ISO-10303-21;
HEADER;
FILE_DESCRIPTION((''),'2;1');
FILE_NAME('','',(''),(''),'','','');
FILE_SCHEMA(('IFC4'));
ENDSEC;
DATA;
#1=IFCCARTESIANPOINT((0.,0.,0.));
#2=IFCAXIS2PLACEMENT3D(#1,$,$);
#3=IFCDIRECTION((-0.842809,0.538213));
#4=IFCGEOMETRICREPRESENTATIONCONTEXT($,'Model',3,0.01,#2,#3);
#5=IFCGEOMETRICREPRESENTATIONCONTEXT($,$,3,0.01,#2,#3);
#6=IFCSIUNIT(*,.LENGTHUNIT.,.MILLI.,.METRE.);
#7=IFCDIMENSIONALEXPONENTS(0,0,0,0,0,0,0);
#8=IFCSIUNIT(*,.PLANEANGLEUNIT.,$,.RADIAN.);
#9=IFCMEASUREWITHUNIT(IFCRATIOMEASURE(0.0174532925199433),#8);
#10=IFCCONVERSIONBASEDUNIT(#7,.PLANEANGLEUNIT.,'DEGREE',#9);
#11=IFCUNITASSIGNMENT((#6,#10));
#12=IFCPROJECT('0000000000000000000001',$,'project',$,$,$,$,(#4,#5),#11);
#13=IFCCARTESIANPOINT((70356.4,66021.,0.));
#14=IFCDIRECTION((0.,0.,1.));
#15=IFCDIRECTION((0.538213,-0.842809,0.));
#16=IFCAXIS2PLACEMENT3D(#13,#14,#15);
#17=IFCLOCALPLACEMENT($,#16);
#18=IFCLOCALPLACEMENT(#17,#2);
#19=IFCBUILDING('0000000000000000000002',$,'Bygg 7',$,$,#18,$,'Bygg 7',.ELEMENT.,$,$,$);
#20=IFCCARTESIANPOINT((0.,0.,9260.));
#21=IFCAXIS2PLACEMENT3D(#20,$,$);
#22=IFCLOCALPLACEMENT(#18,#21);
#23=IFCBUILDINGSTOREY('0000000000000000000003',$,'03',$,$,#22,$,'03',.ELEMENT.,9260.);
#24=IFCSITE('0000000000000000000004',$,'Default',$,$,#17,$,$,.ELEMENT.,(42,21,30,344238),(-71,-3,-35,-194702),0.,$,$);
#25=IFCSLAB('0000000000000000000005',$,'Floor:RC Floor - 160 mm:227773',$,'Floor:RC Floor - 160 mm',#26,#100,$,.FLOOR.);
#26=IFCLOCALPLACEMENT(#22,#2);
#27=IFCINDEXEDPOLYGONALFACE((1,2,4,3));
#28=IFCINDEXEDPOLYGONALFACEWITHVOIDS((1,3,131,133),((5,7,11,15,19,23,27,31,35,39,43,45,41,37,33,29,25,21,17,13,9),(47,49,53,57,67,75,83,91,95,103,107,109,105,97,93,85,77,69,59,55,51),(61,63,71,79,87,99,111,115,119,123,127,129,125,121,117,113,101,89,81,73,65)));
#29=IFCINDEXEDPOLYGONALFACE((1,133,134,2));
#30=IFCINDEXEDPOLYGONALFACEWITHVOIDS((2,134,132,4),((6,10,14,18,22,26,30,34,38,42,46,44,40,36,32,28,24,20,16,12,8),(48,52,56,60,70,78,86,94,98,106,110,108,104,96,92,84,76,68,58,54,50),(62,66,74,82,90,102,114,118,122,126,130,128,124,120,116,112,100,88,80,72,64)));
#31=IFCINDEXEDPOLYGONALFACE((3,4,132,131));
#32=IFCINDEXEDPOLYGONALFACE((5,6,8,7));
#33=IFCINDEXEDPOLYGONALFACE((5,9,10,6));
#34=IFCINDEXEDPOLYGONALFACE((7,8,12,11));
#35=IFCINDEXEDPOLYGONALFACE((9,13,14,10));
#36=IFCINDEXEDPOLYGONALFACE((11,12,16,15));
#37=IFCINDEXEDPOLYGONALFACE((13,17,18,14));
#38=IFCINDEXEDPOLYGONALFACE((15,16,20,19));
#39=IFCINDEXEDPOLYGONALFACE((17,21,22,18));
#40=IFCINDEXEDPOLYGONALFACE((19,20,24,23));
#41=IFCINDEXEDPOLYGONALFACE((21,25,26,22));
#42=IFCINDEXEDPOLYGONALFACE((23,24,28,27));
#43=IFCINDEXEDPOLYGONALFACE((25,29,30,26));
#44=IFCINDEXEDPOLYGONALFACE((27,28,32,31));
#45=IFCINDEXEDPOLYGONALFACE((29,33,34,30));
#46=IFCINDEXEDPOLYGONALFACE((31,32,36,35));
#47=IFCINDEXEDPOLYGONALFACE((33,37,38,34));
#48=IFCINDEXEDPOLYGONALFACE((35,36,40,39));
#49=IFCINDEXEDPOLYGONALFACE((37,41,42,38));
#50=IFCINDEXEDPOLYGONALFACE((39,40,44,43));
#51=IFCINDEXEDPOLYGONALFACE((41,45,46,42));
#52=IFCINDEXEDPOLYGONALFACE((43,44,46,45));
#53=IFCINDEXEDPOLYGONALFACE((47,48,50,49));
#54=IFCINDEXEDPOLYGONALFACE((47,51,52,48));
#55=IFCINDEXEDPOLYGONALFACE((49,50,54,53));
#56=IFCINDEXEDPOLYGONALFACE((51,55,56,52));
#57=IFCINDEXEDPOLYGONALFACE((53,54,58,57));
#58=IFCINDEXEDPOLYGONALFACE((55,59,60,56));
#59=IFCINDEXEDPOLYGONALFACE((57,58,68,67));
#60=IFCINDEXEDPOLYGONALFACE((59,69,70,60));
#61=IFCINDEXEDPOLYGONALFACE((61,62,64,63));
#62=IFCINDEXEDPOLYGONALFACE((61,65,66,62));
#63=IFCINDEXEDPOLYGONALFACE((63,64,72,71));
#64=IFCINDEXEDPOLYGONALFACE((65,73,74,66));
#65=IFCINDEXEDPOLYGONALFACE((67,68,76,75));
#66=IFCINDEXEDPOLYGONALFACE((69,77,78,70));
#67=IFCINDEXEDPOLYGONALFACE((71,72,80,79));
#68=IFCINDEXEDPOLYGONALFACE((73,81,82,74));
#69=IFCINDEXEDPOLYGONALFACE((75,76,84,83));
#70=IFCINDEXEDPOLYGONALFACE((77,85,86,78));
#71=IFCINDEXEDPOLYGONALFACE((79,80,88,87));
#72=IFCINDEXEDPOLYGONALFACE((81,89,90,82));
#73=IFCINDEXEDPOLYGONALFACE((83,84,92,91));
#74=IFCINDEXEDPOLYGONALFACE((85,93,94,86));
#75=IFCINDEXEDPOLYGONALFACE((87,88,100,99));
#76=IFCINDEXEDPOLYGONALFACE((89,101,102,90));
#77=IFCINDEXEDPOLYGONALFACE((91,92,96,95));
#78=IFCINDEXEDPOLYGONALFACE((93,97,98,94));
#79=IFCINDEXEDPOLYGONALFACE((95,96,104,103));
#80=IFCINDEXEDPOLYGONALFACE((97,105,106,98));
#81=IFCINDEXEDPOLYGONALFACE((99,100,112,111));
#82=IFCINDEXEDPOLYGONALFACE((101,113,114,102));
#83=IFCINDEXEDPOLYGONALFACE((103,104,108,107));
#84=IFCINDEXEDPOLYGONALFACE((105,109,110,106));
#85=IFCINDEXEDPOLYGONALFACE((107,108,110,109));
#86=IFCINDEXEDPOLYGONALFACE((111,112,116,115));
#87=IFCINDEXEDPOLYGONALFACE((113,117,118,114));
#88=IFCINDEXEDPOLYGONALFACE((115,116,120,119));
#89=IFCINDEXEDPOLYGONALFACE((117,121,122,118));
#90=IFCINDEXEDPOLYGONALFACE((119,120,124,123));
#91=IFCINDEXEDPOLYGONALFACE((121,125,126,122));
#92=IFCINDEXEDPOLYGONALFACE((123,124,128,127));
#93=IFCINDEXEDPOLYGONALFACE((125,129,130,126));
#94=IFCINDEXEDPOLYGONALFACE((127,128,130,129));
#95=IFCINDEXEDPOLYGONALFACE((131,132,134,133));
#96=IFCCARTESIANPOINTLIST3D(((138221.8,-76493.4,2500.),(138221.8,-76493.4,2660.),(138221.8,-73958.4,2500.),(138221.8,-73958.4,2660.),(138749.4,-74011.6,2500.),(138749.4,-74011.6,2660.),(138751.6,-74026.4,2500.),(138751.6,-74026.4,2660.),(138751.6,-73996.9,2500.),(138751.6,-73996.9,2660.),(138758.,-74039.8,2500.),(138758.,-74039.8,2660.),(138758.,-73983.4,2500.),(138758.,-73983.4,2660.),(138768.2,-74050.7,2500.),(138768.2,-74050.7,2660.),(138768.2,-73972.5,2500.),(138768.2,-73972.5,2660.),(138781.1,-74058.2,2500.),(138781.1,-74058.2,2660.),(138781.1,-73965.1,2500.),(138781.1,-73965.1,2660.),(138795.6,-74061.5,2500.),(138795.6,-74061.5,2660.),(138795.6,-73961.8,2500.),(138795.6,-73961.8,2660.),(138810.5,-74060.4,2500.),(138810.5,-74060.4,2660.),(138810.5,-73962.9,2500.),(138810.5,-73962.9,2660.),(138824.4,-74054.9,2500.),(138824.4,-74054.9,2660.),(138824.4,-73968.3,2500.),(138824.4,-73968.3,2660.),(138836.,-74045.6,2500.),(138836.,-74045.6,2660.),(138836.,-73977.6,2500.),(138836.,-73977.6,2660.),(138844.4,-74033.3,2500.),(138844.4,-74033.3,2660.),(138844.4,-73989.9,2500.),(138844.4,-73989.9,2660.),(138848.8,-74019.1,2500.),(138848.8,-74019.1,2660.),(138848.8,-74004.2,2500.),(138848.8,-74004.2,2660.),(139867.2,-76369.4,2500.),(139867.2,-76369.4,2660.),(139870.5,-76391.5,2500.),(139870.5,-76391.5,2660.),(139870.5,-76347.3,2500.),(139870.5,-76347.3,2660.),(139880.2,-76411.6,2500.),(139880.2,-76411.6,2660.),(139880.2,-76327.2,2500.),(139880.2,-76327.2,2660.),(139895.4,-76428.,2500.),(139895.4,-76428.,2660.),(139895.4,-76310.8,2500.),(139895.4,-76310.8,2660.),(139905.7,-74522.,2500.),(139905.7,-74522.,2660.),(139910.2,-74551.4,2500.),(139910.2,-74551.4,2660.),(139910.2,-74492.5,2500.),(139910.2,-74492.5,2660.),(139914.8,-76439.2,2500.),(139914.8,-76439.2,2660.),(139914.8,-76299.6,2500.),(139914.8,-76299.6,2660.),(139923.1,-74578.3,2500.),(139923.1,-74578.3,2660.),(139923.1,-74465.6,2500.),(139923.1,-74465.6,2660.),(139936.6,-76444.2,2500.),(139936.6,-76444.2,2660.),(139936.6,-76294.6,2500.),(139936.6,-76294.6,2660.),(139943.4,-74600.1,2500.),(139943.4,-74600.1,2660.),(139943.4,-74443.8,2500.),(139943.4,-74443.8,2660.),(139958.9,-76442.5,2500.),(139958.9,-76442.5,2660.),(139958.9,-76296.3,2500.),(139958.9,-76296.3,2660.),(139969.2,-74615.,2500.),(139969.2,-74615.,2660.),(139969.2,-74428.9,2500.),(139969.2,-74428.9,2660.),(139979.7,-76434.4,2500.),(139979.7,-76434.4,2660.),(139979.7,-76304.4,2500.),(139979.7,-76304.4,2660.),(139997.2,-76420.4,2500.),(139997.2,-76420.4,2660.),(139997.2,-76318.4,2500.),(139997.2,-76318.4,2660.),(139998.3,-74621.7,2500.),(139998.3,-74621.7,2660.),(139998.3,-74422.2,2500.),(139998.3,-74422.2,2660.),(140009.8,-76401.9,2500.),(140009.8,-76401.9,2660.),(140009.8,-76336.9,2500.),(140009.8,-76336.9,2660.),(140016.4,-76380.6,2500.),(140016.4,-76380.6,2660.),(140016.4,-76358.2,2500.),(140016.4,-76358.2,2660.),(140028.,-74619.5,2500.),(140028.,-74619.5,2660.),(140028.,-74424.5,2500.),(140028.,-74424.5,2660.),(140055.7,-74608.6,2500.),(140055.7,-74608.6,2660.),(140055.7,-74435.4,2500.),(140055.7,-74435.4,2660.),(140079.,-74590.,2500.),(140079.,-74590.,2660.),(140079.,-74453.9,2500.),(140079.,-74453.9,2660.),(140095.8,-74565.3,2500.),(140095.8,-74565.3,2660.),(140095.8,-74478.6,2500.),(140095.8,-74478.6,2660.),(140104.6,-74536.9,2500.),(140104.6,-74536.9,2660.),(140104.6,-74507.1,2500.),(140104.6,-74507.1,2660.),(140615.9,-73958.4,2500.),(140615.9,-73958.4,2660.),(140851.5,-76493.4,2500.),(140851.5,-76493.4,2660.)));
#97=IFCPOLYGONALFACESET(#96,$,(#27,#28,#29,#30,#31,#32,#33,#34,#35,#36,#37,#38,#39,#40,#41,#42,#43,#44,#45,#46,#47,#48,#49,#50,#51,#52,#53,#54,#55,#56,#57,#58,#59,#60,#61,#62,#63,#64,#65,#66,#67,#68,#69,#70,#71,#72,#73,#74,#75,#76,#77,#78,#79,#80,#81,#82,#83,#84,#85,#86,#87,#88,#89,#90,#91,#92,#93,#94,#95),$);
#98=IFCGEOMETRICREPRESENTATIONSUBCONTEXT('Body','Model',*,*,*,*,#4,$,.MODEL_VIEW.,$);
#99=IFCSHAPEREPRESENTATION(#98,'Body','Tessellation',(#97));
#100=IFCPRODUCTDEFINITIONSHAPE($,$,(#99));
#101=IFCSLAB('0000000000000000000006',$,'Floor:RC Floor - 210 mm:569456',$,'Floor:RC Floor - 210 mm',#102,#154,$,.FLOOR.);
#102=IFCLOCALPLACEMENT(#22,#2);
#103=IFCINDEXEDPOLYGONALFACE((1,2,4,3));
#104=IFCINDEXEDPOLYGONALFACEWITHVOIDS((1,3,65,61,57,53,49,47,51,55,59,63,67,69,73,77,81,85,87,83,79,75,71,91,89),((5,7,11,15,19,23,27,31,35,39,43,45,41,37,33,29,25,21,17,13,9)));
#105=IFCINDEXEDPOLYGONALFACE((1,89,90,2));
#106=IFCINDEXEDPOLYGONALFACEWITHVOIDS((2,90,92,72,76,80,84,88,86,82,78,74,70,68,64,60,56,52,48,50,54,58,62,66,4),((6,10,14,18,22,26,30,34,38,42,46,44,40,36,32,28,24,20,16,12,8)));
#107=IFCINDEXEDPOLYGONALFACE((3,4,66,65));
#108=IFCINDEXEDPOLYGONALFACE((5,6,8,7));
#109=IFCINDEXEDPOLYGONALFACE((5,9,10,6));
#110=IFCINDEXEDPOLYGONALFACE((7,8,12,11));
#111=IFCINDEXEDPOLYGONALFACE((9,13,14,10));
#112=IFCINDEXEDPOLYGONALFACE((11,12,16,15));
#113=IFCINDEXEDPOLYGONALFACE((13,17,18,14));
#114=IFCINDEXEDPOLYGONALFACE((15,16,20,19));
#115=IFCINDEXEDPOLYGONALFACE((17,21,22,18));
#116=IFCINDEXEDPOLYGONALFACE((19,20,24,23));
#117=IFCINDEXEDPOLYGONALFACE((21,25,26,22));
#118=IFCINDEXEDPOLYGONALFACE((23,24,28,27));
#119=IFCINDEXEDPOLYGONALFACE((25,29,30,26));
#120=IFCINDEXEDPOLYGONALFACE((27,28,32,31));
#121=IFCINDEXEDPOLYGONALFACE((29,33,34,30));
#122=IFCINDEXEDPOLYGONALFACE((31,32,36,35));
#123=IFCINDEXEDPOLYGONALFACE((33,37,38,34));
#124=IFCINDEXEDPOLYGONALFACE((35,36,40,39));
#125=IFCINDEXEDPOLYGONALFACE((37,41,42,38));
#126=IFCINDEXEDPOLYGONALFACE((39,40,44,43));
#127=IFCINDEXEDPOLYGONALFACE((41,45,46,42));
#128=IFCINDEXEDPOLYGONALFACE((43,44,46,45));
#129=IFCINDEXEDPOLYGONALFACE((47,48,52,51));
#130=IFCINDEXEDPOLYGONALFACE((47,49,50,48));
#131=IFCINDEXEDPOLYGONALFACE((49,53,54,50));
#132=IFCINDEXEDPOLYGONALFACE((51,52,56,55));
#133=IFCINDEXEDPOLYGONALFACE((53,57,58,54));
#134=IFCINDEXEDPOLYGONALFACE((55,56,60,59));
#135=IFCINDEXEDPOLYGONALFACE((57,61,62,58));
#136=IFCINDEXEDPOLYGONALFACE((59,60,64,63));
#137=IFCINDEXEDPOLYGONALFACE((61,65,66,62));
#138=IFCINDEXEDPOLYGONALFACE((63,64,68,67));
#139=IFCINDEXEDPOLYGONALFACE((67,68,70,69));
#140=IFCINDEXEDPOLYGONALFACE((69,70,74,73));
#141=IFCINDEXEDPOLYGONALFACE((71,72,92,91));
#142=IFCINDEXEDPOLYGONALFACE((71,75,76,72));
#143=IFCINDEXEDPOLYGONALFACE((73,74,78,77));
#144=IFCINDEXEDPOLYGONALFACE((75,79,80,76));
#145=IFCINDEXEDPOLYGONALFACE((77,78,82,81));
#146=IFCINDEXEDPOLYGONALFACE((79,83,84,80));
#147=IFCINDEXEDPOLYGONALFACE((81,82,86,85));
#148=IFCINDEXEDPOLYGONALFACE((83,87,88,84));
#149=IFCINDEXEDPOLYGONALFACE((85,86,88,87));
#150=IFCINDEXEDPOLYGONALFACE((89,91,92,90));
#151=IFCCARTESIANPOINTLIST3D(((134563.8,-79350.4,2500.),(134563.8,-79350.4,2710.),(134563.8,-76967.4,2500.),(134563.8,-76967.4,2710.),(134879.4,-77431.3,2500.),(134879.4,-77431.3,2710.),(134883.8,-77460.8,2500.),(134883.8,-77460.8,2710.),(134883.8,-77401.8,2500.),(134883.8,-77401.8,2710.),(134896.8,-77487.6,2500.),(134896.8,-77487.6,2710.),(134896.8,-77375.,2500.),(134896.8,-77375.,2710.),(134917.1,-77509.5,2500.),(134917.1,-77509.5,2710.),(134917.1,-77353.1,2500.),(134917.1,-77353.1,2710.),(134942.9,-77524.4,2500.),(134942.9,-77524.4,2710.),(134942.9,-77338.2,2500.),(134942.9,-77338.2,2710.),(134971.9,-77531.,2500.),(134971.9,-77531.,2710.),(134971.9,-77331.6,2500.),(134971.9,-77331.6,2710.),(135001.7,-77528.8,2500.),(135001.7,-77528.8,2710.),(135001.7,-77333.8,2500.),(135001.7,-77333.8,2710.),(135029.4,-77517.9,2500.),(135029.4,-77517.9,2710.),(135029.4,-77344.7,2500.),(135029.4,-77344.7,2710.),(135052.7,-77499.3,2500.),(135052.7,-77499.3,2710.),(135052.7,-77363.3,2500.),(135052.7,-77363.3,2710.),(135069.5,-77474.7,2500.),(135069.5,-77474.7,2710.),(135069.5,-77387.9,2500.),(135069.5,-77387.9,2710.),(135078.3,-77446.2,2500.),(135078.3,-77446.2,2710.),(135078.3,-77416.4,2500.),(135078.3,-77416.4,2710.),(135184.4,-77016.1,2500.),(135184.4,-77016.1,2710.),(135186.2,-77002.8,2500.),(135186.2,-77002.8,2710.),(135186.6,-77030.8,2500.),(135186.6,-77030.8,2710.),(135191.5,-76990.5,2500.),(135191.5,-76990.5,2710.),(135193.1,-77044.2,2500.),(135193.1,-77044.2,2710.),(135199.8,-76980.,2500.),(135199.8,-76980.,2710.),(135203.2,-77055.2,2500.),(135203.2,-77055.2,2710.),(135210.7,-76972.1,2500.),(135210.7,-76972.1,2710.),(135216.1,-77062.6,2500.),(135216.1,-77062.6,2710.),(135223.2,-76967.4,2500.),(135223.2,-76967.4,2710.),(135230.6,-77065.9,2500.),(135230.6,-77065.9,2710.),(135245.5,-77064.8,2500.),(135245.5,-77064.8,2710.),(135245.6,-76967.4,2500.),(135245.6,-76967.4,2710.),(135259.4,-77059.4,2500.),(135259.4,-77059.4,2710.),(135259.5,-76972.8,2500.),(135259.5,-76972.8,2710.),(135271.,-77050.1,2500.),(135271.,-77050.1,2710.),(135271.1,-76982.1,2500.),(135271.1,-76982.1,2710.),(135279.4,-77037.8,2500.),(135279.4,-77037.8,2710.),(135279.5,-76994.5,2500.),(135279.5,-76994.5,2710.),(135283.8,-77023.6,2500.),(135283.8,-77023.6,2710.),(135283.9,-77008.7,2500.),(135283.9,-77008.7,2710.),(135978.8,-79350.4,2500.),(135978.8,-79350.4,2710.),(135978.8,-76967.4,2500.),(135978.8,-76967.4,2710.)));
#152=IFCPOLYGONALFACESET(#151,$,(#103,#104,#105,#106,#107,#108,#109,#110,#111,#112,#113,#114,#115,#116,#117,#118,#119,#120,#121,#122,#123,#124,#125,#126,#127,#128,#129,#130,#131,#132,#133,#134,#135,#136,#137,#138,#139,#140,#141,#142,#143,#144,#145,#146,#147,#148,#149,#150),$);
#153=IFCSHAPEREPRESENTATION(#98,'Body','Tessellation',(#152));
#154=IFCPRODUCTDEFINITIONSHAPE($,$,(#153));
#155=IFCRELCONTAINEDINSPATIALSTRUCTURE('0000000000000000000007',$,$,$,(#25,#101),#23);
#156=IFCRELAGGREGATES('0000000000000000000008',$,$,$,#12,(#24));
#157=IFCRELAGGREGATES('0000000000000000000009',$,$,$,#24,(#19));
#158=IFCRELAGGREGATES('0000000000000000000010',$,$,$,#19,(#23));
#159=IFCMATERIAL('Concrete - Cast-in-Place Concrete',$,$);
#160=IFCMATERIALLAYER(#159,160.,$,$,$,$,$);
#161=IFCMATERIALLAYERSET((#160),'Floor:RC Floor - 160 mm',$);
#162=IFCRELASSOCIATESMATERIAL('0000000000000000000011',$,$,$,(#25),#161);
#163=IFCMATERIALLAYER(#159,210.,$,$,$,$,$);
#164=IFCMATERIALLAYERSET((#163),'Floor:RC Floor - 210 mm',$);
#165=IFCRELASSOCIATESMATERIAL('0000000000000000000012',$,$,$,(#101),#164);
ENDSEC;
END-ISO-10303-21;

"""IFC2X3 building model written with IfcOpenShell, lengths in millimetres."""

from ifc_helpers import new_model, entity, si_unit, converted_unit, direction, frame, frame_2d, origin, place, context, subcontext, project, spatial, polyline, rectangle, circle, outline, extrude, material, layer, layer_set, layer_usage, element, save


model = new_model("IFC2X3")

# Units and contexts
model_context = context("Model", 3, precision=0.01, world=origin(), true_north=direction((-0.842809, 0.538213)))
context_of_model = context(None, 3, precision=0.01, world=origin(), true_north=direction((-0.842809, 0.538213)))
body_context = subcontext(model_context, "Body", "Model", "MODEL_VIEW")
ifc_project = project(units=[si_unit("LENGTHUNIT", "METRE", prefix="MILLI"), converted_unit("PLANEANGLEUNIT", "DEGREE", entity("IfcRatioMeasure", 0.0174532925199433), si_unit("PLANEANGLEUNIT", "RADIAN"), dimensions=[0, 0, 0, 0, 0, 0, 0])], contexts=[model_context, context_of_model])

# Site, building, storey
site_placement = place(None, frame((70356.4, 66021.0, 0.0), z_axis=(0.0, 0.0, 1.0), x_axis=(0.538213, -0.842809, 0.0)))
site = spatial("IfcSite", under=ifc_project, at=site_placement, Name="Default", CompositionType="ELEMENT", RefLatitude=(42, 21, 30, 344238), RefLongitude=(-71, -3, -35, -194702), RefElevation=0.0)
building_placement = place(site_placement, origin())
building = spatial("IfcBuilding", under=site, at=building_placement, Name="Bygg 7", LongName="Bygg 7", CompositionType="ELEMENT")
storey_placement = place(building_placement, frame((0.0, 0.0, 9260.0)))
storey = spatial("IfcBuildingStorey", under=building, at=storey_placement, Name="03", LongName="03", CompositionType="ELEMENT", Elevation=9260.0)

# Slabs, openings
ifc_material_1 = material(Name="Concrete - Cast-in-Place Concrete")
ifc_layer_1 = layer(ifc_material_1, 160.0)
ifc_layer_set_1 = layer_set([ifc_layer_1], Name="Floor:RC Floor - 160 mm")
ifc_layer_usage_1 = layer_usage(ifc_layer_set_1, "AXIS3", "POSITIVE", 0.0)
slab_1_placement = place(storey_placement, frame((138221.8, -76493.4, 2500.0)))
slab_1 = element("IfcSlab", 1, at=slab_1_placement, inside=storey, material=ifc_layer_usage_1, Name="Floor:RC Floor - 160 mm:227773", ObjectType="Floor:RC Floor - 160 mm", PredefinedType="FLOOR", context=body_context, shape_type="SweptSolid", body=[
    extrude(outline(polyline([(1314.8, 1267.5), (-1079.2, 1267.5), (-1314.8, -1267.5), (1314.8, -1267.5), (1314.8, 1267.5)])), frame((1314.8, 1267.5, 160.0), z_axis=(0.0, 0.0, -1.0), x_axis=(-1.0, 0.0, 0.0)), (0.0, 0.0, 1.0), 160.0),
])
opening_1_placement = place(storey_placement, frame((138221.8, -76493.4, 2500.0)))
element("IfcOpeningElement", 2, at=opening_1_placement, cuts=slab_1, ObjectType="Opening", context=body_context, shape_type="SweptSolid", body=[
    extrude(circle(Radius=75.0, at=frame_2d((-405.6, -1143.5), x_axis=(1.0, 0.0))), frame((1314.8, 1267.5, 160.0), z_axis=(0.0, 0.0, -1.0), x_axis=(-1.0, 0.0, 0.0)), (0.0, 0.0, 1.0), 160.0),
])
opening_2_placement = place(storey_placement, frame((138221.8, -76493.4, 2500.0)))
element("IfcOpeningElement", 3, at=opening_2_placement, cuts=slab_1, ObjectType="Opening", context=body_context, shape_type="SweptSolid", body=[
    extrude(circle(Radius=50.0, at=frame_2d((737.3, 1214.2), x_axis=(1.0, 0.0))), frame((1314.8, 1267.5, 160.0), z_axis=(0.0, 0.0, -1.0), x_axis=(-1.0, 0.0, 0.0)), (0.0, 0.0, 1.0), 160.0),
])
opening_3_placement = place(storey_placement, frame((138221.8, -76493.4, 2500.0)))
element("IfcOpeningElement", 4, at=opening_3_placement, cuts=slab_1, ObjectType="Opening", context=body_context, shape_type="SweptSolid", body=[
    extrude(circle(Radius=100.0, at=frame_2d((-469.1, 703.9), x_axis=(1.0, 0.0))), frame((1314.8, 1267.5, 160.0), z_axis=(0.0, 0.0, -1.0), x_axis=(-1.0, 0.0, 0.0)), (0.0, 0.0, 1.0), 160.0),
])
ifc_layer_2 = layer(ifc_material_1, 210.0)
ifc_layer_set_2 = layer_set([ifc_layer_2], Name="Floor:RC Floor - 210 mm")
ifc_layer_usage_2 = layer_usage(ifc_layer_set_2, "AXIS3", "POSITIVE", 0.0)
slab_2_placement = place(storey_placement, frame((134563.8, -79350.4, 2500.0)))
slab_2 = element("IfcSlab", 5, at=slab_2_placement, inside=storey, material=ifc_layer_usage_2, Name="Floor:RC Floor - 210 mm:569456", ObjectType="Floor:RC Floor - 210 mm", PredefinedType="FLOOR", context=body_context, shape_type="SweptSolid", body=[
    extrude(rectangle(XDim=1415.0, YDim=2396.0, at=frame_2d((0.0, -6.5), x_axis=(-1.0, 0.0))), frame((707.5, 1191.5, 210.0), z_axis=(0.0, 0.0, -1.0), x_axis=(-1.0, 0.0, 0.0)), (0.0, 0.0, 1.0), 210.0),
])
opening_4_placement = place(storey_placement, frame((134563.8, -79350.4, 2500.0)))
element("IfcOpeningElement", 6, at=opening_4_placement, cuts=slab_2, ObjectType="Opening", context=body_context, shape_type="SweptSolid", body=[
    extrude(rectangle(XDim=1415.0, YDim=577.0, at=frame_2d((0.0, -1480.0), x_axis=(1.0, 0.0))), frame((707.5, 1191.5, 210.0), z_axis=(0.0, 0.0, -1.0), x_axis=(-1.0, 0.0, 0.0)), (0.0, 0.0, 1.0), 210.0),
])
opening_5_placement = place(storey_placement, frame((134563.8, -79350.4, 2500.0)))
element("IfcOpeningElement", 7, at=opening_5_placement, cuts=slab_2, ObjectType="Opening", context=body_context, shape_type="SweptSolid", body=[
    extrude(circle(Radius=100.0, at=frame_2d((291.9, 727.6), x_axis=(1.0, 0.0))), frame((707.5, 1191.5, 210.0), z_axis=(0.0, 0.0, -1.0), x_axis=(-1.0, 0.0, 0.0)), (0.0, 0.0, 1.0), 210.0),
])
opening_6_placement = place(storey_placement, frame((134563.8, -79350.4, 2500.0)))
element("IfcOpeningElement", 8, at=opening_6_placement, cuts=slab_2, ObjectType="Opening", context=body_context, shape_type="SweptSolid", body=[
    extrude(circle(Radius=50.0, at=frame_2d((36.9, 1142.8), x_axis=(1.0, 0.0))), frame((707.5, 1191.5, 210.0), z_axis=(0.0, 0.0, -1.0), x_axis=(-1.0, 0.0, 0.0)), (0.0, 0.0, 1.0), 210.0),
])

save(model, "model.ifc")
